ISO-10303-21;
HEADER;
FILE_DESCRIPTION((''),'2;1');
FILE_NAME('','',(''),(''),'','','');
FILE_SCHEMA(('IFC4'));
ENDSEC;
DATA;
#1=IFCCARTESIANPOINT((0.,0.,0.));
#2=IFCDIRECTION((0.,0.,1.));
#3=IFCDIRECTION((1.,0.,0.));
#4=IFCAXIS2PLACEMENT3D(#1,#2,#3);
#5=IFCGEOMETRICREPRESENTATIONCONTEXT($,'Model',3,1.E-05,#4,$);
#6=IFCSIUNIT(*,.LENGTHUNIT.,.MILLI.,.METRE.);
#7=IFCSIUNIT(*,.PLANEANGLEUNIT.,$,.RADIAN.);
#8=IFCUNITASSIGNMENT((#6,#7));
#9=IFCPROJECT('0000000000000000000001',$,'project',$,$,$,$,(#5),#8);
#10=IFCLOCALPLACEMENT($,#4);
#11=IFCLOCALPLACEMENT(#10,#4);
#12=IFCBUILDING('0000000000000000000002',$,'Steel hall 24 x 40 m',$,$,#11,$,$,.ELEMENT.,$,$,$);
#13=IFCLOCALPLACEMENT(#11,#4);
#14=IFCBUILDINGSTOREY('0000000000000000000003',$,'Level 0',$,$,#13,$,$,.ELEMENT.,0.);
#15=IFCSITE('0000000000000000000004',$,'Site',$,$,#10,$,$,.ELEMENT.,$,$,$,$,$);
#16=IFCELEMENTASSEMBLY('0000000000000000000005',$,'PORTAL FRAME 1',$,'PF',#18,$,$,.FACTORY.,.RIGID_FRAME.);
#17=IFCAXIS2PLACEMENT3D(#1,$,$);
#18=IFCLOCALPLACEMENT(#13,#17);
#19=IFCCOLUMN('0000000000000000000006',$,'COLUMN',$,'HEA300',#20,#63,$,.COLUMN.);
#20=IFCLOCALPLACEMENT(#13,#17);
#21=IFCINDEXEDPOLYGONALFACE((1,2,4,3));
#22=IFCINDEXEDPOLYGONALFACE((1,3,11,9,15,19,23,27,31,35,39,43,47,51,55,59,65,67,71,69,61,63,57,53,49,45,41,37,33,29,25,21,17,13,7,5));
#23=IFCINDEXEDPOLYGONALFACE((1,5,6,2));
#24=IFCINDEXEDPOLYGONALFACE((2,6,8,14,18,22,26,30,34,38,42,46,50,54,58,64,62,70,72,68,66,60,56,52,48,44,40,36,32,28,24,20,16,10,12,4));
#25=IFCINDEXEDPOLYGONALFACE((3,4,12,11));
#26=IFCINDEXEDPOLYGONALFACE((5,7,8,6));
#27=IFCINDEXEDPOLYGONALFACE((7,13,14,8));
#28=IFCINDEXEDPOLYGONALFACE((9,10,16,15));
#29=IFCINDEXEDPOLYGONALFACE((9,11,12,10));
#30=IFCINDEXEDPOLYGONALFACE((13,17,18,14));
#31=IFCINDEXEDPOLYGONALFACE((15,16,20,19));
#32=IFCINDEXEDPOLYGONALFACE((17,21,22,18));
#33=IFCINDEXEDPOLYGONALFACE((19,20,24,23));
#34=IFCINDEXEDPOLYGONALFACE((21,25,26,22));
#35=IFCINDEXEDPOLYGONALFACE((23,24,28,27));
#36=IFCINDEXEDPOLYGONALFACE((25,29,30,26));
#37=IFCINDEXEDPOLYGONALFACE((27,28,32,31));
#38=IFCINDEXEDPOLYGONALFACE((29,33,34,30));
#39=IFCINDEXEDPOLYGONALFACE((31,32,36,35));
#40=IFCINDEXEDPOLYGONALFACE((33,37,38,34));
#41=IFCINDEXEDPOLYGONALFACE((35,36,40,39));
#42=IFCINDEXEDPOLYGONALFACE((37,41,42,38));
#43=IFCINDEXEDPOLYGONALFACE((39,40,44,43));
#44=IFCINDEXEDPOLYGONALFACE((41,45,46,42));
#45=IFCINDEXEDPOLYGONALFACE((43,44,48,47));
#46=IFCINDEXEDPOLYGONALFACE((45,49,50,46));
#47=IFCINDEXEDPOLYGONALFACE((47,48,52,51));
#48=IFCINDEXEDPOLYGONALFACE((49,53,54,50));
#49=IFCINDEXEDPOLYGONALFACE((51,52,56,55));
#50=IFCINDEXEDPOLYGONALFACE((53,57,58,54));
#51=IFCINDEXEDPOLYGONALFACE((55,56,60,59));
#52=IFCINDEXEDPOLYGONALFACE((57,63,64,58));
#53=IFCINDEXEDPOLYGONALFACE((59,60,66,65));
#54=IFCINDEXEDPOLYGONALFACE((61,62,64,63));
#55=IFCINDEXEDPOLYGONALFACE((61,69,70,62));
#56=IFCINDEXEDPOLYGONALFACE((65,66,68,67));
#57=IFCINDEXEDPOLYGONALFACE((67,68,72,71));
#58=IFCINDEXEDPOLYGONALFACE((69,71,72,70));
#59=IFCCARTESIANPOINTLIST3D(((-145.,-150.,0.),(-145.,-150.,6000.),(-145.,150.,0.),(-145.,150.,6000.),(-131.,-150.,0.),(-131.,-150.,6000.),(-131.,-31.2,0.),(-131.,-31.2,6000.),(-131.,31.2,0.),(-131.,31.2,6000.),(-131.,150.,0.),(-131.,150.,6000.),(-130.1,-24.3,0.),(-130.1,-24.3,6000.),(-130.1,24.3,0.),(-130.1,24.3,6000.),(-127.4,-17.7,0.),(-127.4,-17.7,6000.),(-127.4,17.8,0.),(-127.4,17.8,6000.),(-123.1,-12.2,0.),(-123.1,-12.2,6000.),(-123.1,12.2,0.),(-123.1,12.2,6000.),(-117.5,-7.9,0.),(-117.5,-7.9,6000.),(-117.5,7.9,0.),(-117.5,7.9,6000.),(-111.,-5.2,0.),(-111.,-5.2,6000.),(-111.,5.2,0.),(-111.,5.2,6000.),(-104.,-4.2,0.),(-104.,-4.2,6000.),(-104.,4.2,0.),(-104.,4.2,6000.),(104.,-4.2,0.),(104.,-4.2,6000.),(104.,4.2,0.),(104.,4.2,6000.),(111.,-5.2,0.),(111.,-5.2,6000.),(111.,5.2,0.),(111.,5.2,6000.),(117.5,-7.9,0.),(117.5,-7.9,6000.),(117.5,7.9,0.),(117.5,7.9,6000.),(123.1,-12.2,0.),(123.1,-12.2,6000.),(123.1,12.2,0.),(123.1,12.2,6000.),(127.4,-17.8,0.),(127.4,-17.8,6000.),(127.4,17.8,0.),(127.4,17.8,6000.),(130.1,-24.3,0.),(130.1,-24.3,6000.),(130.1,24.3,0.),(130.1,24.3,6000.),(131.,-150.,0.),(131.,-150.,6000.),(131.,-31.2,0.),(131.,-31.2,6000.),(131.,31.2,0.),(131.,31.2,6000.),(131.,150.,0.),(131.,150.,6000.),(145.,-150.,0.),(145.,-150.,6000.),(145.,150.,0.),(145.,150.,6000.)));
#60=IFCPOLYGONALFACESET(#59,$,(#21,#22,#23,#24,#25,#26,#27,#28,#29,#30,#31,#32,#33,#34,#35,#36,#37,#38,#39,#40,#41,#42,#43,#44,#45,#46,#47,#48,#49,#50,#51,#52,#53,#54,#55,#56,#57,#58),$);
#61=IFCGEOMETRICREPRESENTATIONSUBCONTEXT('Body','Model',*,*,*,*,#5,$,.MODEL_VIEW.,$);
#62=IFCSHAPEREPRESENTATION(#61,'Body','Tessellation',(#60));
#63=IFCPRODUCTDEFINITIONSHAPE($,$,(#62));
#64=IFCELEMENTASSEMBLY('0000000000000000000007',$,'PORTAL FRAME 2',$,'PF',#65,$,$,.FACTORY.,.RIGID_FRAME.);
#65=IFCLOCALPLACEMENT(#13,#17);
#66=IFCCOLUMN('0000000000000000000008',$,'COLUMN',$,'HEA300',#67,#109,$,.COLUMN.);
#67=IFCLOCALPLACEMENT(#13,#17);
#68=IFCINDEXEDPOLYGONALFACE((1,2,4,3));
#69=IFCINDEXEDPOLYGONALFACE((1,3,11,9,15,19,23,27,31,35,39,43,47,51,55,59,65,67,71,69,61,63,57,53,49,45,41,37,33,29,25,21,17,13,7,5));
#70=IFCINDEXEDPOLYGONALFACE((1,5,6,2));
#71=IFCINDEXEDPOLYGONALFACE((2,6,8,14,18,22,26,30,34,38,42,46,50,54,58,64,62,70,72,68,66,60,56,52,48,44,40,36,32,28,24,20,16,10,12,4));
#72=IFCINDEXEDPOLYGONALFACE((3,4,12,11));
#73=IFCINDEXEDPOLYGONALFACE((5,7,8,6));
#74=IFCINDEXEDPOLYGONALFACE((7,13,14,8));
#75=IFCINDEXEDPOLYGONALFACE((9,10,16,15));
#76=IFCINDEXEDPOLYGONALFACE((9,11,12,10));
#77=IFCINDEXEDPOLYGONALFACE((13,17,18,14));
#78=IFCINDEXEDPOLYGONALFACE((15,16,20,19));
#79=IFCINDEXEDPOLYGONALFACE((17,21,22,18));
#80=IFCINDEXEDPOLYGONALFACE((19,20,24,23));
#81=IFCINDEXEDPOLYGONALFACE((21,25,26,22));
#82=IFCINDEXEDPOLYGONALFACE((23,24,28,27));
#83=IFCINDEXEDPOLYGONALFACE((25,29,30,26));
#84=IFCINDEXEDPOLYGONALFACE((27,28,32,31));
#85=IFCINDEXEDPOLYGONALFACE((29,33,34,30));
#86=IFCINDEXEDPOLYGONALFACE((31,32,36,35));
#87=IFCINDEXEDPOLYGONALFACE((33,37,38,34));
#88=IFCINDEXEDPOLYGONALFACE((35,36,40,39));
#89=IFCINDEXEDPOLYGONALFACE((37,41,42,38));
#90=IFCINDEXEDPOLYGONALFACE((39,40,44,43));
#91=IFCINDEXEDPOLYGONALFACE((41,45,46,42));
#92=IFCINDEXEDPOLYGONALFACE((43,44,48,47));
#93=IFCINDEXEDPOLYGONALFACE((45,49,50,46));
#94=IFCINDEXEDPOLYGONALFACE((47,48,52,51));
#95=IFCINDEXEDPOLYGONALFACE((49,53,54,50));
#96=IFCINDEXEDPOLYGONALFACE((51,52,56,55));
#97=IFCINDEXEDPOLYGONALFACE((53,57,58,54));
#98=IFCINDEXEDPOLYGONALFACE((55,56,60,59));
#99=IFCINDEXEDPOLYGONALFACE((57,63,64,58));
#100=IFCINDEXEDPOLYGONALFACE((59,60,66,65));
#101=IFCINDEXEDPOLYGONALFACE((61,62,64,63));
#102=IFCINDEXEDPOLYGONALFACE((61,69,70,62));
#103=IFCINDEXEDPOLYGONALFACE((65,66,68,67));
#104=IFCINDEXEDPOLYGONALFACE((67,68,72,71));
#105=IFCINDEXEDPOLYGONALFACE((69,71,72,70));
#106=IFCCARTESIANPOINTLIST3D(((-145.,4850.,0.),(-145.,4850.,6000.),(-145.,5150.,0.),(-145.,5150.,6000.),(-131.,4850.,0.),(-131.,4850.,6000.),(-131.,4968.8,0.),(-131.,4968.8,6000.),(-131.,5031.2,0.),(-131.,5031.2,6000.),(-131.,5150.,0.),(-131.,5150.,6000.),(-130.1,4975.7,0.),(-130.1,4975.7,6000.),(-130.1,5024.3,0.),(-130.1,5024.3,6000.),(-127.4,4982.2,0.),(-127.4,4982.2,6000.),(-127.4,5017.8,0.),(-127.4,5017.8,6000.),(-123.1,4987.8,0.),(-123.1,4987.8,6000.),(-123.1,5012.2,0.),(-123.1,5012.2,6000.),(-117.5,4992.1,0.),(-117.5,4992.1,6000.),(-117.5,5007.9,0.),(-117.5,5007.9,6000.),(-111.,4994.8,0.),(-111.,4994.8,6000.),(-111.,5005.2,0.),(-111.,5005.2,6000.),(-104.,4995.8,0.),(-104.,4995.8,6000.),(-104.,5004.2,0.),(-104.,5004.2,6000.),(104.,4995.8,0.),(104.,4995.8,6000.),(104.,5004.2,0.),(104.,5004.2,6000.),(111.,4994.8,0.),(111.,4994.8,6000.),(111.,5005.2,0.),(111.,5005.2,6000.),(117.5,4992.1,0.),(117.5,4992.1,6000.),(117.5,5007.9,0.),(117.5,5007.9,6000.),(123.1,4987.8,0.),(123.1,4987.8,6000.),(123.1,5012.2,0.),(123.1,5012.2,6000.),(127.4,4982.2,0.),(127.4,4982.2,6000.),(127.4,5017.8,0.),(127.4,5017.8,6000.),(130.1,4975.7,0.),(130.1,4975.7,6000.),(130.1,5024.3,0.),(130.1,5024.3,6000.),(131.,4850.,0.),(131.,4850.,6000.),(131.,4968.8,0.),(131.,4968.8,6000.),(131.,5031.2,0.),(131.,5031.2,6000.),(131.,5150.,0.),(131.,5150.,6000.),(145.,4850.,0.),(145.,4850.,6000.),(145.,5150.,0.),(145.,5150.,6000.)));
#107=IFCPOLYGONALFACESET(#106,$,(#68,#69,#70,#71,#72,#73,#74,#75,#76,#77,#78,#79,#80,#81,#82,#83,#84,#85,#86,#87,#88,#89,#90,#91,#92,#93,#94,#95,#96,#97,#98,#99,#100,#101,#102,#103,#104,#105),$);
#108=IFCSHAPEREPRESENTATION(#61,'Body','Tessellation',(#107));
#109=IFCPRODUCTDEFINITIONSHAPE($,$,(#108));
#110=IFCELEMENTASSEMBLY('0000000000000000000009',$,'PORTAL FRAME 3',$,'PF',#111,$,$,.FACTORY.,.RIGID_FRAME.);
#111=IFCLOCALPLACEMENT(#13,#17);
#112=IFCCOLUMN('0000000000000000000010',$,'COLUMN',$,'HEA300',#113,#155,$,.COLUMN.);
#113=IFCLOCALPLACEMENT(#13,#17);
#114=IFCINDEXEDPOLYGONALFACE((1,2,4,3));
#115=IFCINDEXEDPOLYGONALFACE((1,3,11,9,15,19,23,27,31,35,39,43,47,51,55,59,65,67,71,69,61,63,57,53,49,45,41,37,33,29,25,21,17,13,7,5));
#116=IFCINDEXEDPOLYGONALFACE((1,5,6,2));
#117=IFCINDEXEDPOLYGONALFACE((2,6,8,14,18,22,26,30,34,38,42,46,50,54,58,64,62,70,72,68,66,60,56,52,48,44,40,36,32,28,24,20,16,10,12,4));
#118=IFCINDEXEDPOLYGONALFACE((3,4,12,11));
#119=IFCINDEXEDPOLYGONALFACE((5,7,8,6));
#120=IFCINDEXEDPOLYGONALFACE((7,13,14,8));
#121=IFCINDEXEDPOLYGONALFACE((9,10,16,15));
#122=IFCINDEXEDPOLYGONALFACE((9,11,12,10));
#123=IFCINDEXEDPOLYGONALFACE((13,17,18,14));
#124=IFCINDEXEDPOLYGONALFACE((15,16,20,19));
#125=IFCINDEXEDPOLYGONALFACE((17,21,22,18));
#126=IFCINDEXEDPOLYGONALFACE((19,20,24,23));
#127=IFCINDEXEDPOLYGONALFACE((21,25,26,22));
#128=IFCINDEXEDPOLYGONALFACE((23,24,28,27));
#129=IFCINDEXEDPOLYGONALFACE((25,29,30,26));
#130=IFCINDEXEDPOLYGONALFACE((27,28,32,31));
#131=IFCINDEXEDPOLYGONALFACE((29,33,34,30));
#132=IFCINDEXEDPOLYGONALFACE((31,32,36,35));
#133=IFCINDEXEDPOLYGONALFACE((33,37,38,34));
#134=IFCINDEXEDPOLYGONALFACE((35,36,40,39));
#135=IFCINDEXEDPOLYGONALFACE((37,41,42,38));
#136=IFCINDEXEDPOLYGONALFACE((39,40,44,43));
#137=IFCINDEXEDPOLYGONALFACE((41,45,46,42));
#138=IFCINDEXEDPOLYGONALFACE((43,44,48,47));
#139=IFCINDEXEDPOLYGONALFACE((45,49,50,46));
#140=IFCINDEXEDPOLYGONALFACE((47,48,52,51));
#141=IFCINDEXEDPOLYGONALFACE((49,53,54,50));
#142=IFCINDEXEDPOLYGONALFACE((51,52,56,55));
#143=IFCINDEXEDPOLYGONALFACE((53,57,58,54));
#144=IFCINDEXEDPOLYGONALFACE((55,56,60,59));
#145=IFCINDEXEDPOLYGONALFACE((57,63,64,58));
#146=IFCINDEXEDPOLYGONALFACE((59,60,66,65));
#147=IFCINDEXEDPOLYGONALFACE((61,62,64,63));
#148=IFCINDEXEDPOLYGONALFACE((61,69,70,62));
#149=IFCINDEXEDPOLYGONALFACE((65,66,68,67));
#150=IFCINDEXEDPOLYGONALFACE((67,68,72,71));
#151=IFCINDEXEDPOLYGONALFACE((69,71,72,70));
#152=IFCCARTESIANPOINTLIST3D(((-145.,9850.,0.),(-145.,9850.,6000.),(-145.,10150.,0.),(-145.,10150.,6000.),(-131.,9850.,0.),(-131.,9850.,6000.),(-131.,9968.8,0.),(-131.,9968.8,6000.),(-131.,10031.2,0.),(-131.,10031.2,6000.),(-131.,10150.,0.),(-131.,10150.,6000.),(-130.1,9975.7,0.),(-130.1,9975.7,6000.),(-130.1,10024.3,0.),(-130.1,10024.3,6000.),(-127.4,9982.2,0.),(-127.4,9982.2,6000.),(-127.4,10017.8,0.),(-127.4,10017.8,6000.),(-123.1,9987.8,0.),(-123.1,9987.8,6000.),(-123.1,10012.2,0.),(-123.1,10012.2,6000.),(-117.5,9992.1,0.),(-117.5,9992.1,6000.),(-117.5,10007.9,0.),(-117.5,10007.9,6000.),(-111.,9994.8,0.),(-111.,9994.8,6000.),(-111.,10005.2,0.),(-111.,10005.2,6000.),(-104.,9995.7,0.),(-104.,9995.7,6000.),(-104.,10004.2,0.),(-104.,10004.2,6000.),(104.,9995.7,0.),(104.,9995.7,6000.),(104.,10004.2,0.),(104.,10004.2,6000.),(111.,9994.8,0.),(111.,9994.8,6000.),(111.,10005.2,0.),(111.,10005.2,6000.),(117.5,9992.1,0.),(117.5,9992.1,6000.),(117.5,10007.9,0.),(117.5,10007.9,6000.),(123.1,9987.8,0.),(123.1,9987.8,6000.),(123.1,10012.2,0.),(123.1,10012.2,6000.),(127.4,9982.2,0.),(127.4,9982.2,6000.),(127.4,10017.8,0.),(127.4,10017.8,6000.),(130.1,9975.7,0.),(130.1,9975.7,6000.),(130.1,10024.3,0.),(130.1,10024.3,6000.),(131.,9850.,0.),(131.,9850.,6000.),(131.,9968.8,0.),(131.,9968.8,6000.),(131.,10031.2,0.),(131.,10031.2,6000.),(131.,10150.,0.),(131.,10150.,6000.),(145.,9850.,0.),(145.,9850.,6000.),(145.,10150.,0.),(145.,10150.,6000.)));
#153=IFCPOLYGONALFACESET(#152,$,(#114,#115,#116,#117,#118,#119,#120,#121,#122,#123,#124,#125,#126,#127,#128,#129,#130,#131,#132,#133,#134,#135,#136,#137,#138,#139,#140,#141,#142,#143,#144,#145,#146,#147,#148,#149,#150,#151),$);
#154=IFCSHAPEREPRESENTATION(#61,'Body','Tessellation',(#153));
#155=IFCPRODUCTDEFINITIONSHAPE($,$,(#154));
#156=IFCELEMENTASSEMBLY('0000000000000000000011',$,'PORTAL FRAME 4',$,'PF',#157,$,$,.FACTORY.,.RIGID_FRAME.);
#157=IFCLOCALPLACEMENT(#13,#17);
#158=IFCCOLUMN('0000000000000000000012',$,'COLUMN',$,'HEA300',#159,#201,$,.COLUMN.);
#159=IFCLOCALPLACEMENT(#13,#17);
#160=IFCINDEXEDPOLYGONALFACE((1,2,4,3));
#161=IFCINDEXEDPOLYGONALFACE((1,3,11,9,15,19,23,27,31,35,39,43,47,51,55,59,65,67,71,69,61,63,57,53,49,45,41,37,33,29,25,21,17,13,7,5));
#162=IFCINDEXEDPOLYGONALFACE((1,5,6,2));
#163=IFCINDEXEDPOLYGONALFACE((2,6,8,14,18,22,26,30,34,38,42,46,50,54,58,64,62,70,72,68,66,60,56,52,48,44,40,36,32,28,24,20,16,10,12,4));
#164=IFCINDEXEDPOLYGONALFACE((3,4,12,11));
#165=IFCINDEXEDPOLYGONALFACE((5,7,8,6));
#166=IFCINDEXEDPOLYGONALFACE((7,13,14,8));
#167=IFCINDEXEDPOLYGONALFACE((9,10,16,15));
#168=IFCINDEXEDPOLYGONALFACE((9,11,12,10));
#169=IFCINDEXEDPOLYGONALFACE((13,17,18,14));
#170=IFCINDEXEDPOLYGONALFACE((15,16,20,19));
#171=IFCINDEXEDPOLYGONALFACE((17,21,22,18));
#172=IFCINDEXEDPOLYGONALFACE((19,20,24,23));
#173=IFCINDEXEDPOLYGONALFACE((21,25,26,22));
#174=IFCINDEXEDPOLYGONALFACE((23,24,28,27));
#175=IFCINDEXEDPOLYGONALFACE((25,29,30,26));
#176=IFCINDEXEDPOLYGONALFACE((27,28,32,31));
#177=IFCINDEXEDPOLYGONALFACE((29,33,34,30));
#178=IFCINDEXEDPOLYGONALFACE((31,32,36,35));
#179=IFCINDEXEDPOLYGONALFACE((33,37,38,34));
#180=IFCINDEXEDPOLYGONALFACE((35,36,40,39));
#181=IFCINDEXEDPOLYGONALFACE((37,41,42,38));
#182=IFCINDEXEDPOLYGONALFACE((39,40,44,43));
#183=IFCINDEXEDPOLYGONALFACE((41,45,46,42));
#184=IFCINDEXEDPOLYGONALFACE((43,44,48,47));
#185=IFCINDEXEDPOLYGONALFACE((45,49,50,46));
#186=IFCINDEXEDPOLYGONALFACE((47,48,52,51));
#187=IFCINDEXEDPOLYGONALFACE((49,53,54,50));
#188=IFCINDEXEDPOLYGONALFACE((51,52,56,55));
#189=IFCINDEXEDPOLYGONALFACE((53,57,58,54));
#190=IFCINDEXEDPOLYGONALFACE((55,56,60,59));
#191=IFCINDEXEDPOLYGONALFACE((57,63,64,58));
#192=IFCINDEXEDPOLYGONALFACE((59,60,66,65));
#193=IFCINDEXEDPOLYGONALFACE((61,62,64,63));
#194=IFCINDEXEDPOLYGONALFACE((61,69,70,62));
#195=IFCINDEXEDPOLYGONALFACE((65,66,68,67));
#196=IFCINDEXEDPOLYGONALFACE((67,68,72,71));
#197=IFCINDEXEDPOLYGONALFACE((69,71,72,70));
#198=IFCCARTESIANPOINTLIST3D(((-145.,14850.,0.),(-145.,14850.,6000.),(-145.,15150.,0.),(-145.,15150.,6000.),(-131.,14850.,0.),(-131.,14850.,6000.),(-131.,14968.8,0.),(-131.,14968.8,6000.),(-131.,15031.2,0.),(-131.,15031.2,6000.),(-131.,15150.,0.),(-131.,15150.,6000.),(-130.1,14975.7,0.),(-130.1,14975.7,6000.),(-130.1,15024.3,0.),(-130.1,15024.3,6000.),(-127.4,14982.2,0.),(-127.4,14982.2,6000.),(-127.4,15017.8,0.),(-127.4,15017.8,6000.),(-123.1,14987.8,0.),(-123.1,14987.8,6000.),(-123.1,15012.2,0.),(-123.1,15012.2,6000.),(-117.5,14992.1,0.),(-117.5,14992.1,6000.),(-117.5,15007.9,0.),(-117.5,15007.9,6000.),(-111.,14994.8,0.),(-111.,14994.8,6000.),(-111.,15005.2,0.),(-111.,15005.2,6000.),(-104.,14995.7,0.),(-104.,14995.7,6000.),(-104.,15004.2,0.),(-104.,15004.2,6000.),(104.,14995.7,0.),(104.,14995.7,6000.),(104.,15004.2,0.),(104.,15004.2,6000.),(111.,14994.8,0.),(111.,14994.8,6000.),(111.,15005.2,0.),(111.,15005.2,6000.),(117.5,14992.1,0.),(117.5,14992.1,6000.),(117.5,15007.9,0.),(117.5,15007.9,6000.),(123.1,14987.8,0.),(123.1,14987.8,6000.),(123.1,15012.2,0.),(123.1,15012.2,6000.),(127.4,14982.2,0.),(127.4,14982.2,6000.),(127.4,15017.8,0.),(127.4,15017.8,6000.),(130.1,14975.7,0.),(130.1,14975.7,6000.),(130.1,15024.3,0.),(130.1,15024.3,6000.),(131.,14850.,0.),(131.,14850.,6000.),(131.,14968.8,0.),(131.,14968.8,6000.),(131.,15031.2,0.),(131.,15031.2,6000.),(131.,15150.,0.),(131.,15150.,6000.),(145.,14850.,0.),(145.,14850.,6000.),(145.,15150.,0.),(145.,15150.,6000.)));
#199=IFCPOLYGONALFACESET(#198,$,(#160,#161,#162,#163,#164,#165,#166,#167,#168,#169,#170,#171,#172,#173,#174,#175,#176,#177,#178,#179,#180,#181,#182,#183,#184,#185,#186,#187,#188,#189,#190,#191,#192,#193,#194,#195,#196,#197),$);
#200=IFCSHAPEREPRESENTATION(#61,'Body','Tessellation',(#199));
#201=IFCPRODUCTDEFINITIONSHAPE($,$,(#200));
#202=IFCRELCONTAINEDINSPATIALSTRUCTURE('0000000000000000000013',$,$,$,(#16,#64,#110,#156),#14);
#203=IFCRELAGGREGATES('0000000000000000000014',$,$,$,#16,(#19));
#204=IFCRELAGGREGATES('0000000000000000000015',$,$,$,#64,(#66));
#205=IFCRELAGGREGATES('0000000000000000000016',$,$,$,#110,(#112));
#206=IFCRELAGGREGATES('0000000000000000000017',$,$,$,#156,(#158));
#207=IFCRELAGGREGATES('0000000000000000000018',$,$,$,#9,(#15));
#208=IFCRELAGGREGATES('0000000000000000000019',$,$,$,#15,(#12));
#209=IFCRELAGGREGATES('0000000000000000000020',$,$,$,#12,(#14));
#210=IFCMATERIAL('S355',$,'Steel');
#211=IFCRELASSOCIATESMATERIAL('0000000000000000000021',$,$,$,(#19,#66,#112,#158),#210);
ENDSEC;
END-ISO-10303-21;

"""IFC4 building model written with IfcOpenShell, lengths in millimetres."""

from ifc_helpers import new_model, si_unit, frame, origin_with_axes, place, context, subcontext, project, spatial, i_section, extrude, material, element, aggregate, save


model = new_model("IFC4")

# Units and contexts
model_context = context("Model", 3, precision=1e-05, world=origin_with_axes())
body_context = subcontext(model_context, "Body", "Model", "MODEL_VIEW")
ifc_project = project(units=[si_unit("LENGTHUNIT", "METRE", prefix="MILLI"), si_unit("PLANEANGLEUNIT", "RADIAN")], contexts=[model_context])

# Site, building, storey
site_placement = place(None, origin_with_axes())
site = spatial("IfcSite", under=ifc_project, at=site_placement, Name="Site", CompositionType="ELEMENT")
building_placement = place(site_placement, origin_with_axes())
building = spatial("IfcBuilding", under=site, at=building_placement, Name="Steel hall 24 x 40 m", CompositionType="ELEMENT")
storey_placement = place(building_placement, origin_with_axes())
storey = spatial("IfcBuildingStorey", under=building, at=storey_placement, Name="Level 0", CompositionType="ELEMENT", Elevation=0.0)

# Element assemblies, columns
assembly_1_placement = place(storey_placement, origin_with_axes())
assembly_1 = element("IfcElementAssembly", 1, at=assembly_1_placement, inside=storey, Name="PORTAL FRAME 1", ObjectType="PF", AssemblyPlace="FACTORY", PredefinedType="RIGID_FRAME")
ifc_material = material(Name="S355", Category="Steel")
column_1_placement = place(storey_placement, frame((0.0, 0.0, 0.0), z_axis=(0.0, 0.0, 1.0), x_axis=(0.0, 1.0, 0.0)))
column_1 = element("IfcColumn", 2, at=column_1_placement, material=ifc_material, Name="COLUMN", ObjectType="HEA300", PredefinedType="COLUMN", context=body_context, shape_type="SweptSolid", body=[
    extrude(i_section(OverallWidth=300.0, OverallDepth=290.0, WebThickness=8.5, FlangeThickness=14.0, FilletRadius=27.0), origin_with_axes(), (0.0, 0.0, 1.0), 6000.0),
])
assembly_2_placement = place(storey_placement, frame((0.0, 5000.0, 0.0), z_axis=(0.0, 0.0, 1.0), x_axis=(1.0, 0.0, 0.0)))
assembly_2 = element("IfcElementAssembly", 3, at=assembly_2_placement, inside=storey, Name="PORTAL FRAME 2", ObjectType="PF", AssemblyPlace="FACTORY", PredefinedType="RIGID_FRAME")
column_2_placement = place(storey_placement, frame((0.0, 5000.0, 0.0), z_axis=(0.0, 0.0, 1.0), x_axis=(0.0, 1.0, 0.0)))
column_2 = element("IfcColumn", 4, at=column_2_placement, material=ifc_material, Name="COLUMN", ObjectType="HEA300", PredefinedType="COLUMN", context=body_context, shape_type="SweptSolid", body=[
    extrude(i_section(OverallWidth=300.0, OverallDepth=290.0, WebThickness=8.5, FlangeThickness=14.0, FilletRadius=27.0), origin_with_axes(), (0.0, 0.0, 1.0), 6000.0),
])
assembly_3_placement = place(storey_placement, frame((0.0, 10000.0, 0.0), z_axis=(0.0, 0.0, 1.0), x_axis=(1.0, 0.0, 0.0)))
assembly_3 = element("IfcElementAssembly", 5, at=assembly_3_placement, inside=storey, Name="PORTAL FRAME 3", ObjectType="PF", AssemblyPlace="FACTORY", PredefinedType="RIGID_FRAME")
column_3_placement = place(storey_placement, frame((0.0, 10000.0, 0.0), z_axis=(0.0, 0.0, 1.0), x_axis=(0.0, 1.0, 0.0)))
column_3 = element("IfcColumn", 6, at=column_3_placement, material=ifc_material, Name="COLUMN", ObjectType="HEA300", PredefinedType="COLUMN", context=body_context, shape_type="SweptSolid", body=[
    extrude(i_section(OverallWidth=300.0, OverallDepth=290.0, WebThickness=8.5, FlangeThickness=14.0, FilletRadius=27.0), origin_with_axes(), (0.0, 0.0, 1.0), 6000.0),
])
assembly_4_placement = place(storey_placement, frame((0.0, 15000.0, 0.0), z_axis=(0.0, 0.0, 1.0), x_axis=(1.0, 0.0, 0.0)))
assembly_4 = element("IfcElementAssembly", 7, at=assembly_4_placement, inside=storey, Name="PORTAL FRAME 4", ObjectType="PF", AssemblyPlace="FACTORY", PredefinedType="RIGID_FRAME")
column_4_placement = place(storey_placement, frame((0.0, 15000.0, 0.0), z_axis=(0.0, 0.0, 1.0), x_axis=(0.0, 1.0, 0.0)))
column_4 = element("IfcColumn", 8, at=column_4_placement, material=ifc_material, Name="COLUMN", ObjectType="HEA300", PredefinedType="COLUMN", context=body_context, shape_type="SweptSolid", body=[
    extrude(i_section(OverallWidth=300.0, OverallDepth=290.0, WebThickness=8.5, FlangeThickness=14.0, FilletRadius=27.0), origin_with_axes(), (0.0, 0.0, 1.0), 6000.0),
])

aggregate(assembly_1, [column_1])
aggregate(assembly_2, [column_2])
aggregate(assembly_3, [column_3])
aggregate(assembly_4, [column_4])

save(model, "model.ifc")
